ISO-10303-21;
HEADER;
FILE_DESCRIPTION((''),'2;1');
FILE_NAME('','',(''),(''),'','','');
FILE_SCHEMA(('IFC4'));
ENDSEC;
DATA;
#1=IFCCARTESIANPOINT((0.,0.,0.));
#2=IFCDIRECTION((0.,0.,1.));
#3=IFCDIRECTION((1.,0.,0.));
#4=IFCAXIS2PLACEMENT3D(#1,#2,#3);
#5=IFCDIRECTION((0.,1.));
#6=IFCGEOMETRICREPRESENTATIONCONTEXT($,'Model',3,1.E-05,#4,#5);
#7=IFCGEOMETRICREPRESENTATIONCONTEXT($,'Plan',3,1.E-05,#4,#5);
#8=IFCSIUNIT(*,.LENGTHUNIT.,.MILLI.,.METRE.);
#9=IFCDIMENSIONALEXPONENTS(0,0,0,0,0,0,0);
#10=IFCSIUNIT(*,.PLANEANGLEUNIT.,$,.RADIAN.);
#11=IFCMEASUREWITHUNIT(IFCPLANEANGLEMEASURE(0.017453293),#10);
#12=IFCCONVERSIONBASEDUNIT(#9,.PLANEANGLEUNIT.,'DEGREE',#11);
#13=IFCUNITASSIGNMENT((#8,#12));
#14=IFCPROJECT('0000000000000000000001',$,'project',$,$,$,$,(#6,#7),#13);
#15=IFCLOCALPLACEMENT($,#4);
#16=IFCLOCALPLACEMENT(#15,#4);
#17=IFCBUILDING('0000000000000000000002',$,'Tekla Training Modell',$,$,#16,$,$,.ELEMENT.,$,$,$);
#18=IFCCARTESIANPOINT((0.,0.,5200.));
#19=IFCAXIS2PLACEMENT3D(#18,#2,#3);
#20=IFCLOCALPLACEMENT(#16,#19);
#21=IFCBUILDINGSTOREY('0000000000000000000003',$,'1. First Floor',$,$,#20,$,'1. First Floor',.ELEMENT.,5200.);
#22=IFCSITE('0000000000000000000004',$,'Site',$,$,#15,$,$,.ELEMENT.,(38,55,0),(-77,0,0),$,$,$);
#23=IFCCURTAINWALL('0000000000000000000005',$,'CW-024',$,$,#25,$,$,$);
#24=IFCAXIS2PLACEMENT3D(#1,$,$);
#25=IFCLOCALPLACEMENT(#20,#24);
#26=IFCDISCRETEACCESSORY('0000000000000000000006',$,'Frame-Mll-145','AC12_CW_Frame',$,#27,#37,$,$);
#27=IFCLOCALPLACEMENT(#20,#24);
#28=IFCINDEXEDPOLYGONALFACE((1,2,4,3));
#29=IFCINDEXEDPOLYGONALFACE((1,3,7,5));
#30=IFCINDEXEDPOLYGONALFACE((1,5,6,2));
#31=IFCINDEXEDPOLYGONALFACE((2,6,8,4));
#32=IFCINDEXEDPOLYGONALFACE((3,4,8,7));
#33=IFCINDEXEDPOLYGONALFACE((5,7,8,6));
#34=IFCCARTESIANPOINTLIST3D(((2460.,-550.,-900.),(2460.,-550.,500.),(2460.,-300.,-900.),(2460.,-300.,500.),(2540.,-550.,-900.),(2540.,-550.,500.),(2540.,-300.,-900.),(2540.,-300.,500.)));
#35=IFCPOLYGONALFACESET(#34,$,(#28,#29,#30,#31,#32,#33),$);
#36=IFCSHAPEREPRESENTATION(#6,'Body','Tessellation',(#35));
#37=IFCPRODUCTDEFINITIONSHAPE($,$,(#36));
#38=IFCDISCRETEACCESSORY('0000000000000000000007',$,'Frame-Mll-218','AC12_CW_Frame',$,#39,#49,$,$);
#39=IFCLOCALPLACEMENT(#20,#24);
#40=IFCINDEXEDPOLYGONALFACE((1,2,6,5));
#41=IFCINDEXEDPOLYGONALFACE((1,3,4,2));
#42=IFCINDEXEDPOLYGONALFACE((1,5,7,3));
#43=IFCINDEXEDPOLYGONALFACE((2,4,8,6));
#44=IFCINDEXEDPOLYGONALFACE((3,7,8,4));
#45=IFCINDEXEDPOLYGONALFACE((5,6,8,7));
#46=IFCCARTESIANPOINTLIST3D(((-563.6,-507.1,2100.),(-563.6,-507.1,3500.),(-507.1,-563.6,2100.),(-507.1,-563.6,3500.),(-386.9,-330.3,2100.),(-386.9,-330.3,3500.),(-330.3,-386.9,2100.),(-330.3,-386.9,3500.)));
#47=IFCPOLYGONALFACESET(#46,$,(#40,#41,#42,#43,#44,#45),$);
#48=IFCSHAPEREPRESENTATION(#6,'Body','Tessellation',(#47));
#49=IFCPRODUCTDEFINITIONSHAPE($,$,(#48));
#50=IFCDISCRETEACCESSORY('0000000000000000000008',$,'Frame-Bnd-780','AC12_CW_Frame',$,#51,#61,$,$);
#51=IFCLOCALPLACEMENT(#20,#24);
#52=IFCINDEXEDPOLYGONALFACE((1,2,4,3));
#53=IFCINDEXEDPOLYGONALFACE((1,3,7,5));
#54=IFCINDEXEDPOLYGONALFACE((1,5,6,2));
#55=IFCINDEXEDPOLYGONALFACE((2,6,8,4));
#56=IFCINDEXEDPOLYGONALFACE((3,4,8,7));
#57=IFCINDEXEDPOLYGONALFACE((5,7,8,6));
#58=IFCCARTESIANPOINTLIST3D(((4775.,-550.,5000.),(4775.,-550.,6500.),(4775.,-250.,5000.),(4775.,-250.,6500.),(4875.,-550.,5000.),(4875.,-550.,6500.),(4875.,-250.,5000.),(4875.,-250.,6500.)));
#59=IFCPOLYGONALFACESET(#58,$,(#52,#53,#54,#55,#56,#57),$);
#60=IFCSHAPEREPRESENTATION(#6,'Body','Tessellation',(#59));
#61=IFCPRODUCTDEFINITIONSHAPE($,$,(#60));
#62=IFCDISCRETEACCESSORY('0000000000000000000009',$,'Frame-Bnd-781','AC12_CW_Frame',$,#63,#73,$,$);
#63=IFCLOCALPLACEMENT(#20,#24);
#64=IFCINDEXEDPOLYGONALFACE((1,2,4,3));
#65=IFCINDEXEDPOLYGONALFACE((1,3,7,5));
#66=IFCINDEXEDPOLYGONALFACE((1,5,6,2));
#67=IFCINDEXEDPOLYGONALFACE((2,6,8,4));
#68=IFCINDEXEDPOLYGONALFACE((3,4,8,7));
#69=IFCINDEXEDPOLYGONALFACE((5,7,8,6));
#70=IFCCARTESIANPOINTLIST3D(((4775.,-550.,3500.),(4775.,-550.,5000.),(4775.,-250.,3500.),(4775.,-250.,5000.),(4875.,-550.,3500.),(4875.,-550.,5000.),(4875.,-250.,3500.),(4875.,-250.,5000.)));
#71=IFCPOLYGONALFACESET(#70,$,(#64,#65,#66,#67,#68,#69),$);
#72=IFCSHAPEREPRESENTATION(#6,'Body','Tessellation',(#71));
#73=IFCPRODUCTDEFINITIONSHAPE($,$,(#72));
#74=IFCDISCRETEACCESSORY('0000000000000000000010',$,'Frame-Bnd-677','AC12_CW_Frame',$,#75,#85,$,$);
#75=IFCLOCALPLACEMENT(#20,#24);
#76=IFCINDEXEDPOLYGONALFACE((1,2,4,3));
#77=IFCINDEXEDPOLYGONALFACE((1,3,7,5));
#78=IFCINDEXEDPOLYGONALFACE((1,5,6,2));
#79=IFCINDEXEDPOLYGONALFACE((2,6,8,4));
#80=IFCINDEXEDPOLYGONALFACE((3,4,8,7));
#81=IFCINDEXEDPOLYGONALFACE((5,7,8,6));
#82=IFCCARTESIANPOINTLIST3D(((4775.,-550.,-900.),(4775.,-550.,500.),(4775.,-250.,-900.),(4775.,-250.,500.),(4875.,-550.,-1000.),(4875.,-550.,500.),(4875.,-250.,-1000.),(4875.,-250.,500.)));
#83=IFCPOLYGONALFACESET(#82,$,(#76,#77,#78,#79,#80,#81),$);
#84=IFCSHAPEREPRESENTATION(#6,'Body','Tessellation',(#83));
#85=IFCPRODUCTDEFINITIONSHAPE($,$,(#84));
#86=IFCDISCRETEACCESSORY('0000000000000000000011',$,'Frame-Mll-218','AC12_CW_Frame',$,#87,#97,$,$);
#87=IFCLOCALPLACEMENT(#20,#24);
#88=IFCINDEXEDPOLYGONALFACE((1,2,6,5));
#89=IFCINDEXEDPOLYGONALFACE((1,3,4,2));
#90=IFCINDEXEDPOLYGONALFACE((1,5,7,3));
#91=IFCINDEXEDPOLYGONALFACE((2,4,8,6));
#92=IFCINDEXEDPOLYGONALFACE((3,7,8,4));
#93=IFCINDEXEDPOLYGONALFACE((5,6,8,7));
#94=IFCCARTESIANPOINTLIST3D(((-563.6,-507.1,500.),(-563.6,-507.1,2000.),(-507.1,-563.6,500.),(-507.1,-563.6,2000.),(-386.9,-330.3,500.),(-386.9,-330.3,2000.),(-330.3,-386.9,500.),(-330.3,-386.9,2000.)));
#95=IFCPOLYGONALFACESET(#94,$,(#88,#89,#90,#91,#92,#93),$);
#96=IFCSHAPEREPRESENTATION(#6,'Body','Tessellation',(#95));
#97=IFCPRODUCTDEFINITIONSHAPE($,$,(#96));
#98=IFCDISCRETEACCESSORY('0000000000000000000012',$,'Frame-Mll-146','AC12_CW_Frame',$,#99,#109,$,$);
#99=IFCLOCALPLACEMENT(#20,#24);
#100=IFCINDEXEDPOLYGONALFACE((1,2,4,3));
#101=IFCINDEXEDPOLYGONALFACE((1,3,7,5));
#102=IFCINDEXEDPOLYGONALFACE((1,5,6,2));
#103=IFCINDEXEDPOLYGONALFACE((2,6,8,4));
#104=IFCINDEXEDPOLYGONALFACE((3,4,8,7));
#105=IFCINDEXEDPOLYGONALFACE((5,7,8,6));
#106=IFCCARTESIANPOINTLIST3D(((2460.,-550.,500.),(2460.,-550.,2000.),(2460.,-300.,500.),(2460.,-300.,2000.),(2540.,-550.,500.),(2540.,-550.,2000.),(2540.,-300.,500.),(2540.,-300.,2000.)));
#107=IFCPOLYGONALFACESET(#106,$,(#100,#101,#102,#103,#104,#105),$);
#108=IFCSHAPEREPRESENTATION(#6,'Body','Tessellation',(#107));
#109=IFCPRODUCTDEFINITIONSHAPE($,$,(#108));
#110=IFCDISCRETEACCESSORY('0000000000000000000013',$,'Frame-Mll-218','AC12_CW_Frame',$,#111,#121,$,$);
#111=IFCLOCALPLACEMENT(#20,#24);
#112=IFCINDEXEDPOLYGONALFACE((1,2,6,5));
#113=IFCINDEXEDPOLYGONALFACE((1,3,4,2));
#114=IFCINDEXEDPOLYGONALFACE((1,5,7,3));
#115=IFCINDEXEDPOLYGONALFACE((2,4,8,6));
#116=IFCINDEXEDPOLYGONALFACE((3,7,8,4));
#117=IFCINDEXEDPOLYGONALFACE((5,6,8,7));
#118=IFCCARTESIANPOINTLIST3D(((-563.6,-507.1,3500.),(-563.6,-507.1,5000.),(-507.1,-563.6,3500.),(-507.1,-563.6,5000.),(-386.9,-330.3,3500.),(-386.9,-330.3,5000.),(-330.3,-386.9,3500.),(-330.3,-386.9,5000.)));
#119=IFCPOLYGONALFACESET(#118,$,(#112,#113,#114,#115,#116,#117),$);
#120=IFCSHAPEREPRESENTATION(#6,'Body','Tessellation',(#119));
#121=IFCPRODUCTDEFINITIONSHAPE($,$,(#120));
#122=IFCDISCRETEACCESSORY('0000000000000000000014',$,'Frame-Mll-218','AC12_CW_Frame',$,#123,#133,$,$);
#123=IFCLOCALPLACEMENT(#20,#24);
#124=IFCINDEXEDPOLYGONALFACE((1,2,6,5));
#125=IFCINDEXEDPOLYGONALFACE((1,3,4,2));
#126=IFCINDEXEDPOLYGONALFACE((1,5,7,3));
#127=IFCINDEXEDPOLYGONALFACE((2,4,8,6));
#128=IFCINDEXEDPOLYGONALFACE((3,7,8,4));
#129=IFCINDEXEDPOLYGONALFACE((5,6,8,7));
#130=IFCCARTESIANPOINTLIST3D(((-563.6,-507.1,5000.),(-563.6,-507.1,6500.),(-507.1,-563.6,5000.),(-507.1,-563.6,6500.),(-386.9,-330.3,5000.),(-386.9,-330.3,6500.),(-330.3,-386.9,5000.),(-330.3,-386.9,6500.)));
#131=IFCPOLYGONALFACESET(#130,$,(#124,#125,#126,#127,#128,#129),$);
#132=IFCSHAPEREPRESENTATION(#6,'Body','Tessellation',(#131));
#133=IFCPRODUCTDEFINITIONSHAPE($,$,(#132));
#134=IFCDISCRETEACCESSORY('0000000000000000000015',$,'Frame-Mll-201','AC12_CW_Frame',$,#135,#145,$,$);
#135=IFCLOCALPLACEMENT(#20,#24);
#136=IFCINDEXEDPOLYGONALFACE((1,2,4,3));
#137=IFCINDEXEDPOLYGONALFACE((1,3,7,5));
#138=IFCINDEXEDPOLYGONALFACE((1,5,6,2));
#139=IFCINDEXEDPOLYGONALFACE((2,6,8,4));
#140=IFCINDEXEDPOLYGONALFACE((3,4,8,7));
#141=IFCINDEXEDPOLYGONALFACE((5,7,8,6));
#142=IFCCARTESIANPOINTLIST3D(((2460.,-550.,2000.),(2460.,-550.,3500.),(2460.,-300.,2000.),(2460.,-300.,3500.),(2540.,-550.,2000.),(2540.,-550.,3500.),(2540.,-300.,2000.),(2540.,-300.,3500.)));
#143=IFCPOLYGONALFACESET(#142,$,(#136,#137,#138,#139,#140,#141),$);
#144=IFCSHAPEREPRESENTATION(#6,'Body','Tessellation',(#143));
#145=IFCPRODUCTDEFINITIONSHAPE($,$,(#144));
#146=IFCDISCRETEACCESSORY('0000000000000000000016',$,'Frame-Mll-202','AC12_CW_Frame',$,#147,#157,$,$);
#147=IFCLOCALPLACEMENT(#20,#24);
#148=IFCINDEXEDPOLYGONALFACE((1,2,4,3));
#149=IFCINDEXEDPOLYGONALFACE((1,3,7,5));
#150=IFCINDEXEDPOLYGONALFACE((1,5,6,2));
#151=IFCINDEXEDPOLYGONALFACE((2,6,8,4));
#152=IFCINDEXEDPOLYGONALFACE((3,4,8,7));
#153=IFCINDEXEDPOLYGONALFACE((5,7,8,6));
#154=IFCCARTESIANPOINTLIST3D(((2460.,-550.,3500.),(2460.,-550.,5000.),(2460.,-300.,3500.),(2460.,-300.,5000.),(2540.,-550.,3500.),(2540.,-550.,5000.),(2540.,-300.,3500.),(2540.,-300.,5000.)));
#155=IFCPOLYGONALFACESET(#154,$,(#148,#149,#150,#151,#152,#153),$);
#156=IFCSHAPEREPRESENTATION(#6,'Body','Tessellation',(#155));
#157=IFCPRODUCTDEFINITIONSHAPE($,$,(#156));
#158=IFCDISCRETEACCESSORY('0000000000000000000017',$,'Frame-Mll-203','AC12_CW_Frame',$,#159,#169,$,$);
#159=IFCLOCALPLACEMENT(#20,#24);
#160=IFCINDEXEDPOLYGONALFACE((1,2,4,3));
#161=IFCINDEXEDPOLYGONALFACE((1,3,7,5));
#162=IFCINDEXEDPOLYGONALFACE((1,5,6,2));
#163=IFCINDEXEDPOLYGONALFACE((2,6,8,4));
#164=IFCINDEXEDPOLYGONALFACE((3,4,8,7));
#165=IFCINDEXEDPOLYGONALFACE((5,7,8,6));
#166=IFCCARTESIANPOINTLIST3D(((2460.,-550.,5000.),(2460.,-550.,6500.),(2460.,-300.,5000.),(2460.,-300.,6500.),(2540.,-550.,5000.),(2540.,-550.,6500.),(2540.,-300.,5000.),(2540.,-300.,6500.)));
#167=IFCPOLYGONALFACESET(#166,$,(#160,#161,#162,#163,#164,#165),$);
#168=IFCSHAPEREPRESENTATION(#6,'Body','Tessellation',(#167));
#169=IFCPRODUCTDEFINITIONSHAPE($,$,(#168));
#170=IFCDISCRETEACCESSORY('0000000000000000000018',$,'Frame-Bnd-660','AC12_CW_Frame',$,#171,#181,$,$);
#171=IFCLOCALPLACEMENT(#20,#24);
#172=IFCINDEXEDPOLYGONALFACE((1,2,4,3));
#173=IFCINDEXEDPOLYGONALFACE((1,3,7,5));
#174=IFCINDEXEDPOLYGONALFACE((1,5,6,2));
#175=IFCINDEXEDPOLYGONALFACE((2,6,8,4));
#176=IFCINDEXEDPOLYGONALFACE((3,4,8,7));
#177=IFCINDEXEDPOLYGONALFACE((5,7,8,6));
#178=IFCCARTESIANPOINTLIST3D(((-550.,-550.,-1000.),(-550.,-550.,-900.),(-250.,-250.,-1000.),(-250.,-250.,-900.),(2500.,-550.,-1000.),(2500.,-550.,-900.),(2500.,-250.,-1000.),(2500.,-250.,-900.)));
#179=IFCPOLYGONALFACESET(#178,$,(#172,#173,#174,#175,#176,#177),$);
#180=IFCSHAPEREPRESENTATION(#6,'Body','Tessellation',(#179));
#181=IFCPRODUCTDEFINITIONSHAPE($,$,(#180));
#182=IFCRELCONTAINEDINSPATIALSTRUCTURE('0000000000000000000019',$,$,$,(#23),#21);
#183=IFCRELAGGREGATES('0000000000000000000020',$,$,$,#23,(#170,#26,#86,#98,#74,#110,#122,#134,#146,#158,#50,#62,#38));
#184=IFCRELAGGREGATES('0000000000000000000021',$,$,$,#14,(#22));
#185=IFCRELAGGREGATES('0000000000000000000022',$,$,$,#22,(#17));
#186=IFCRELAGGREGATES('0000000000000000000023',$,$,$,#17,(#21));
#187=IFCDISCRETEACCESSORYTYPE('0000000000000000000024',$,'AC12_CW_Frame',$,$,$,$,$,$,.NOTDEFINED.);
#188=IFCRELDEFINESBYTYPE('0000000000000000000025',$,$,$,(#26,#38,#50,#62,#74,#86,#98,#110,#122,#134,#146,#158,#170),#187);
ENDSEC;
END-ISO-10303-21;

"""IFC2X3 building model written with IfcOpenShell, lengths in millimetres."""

from ifc_helpers import new_model, entity, si_unit, converted_unit, direction, frame, origin_with_axes, place, context, project, spatial, polyline, outline, extrude, source, transform, mapped, type_object, element, aggregate, save


model = new_model("IFC2X3")

# Units and contexts
model_context = context("Model", 3, precision=1e-05, world=origin_with_axes(), true_north=direction((0.0, 1.0)))
plan_context = context("Plan", 3, precision=1e-05, world=origin_with_axes(), true_north=direction((0.0, 1.0)))
ifc_project = project(units=[si_unit("LENGTHUNIT", "METRE", prefix="MILLI"), converted_unit("PLANEANGLEUNIT", "DEGREE", entity("IfcPlaneAngleMeasure", 0.017453293), si_unit("PLANEANGLEUNIT", "RADIAN"), dimensions=[0, 0, 0, 0, 0, 0, 0])], contexts=[model_context, plan_context])

# Site, building, storey
site_placement = place(None, origin_with_axes())
site = spatial("IfcSite", under=ifc_project, at=site_placement, Name="Site", CompositionType="ELEMENT", RefLatitude=(38, 55, 0), RefLongitude=(-77, 0, 0))
building_placement = place(site_placement, origin_with_axes())
building = spatial("IfcBuilding", under=site, at=building_placement, Name="Tekla Training Modell", CompositionType="ELEMENT")
storey_placement = place(building_placement, frame((0.0, 0.0, 5200.0), z_axis=(0.0, 0.0, 1.0), x_axis=(1.0, 0.0, 0.0)))
storey = spatial("IfcBuildingStorey", under=building, at=storey_placement, Name="1. First Floor", LongName="1. First Floor", CompositionType="ELEMENT", Elevation=5200.0)

# Curtain wall, discrete accessories
curtain_wall_placement = place(storey_placement, frame((-500.0, 6800.2, -1000.0), z_axis=(0.0, 0.0, 1.0), x_axis=(0.0, -1.0, 0.0)))
curtain_wall = element("IfcCurtainWall", 1, at=curtain_wall_placement, inside=storey, Name="CW-024")
discrete_accessory_type = type_object("IfcDiscreteAccessoryType", Name="AC12_CW_Frame")
shared_shape_1 = source(origin_with_axes(), model_context, "Body", "SweptSolid", [
    extrude(outline(polyline([(0.0, 0.0), (250.0, 0.0), (250.0, -1400.0), (0.0, -1400.0), (0.0, 0.0)])), origin_with_axes(), (0.0, 0.0, 1.0), 80.0),
])
discrete_accessory_1_placement = place(storey_placement, frame((2460.0, -300.0, -900.0), z_axis=(1.0, 0.0, 0.0), x_axis=(0.0, -1.0, 0.0)))
discrete_accessory_1 = element("IfcDiscreteAccessory", 2, at=discrete_accessory_1_placement, type_object=discrete_accessory_type, Name="Frame-Mll-145", Description="AC12_CW_Frame", context=model_context, shape_type="MappedRepresentation", body=[
    mapped(shared_shape_1, transform((0.0, 0.0, 0.0), scale=1.0)),
])
discrete_accessory_2_placement = place(storey_placement, frame((-386.9, -330.3, 2100.0), z_axis=(0.707107, -0.707107, 0.0), x_axis=(-0.707107, -0.707107, 0.0)))
discrete_accessory_2 = element("IfcDiscreteAccessory", 3, at=discrete_accessory_2_placement, type_object=discrete_accessory_type, Name="Frame-Mll-218", Description="AC12_CW_Frame", context=model_context, shape_type="MappedRepresentation", body=[
    mapped(shared_shape_1, transform((0.0, 0.0, 0.0), scale=1.0)),
])
shared_shape_2 = source(origin_with_axes(), model_context, "Body", "SweptSolid", [
    extrude(outline(polyline([(0.0, 0.0), (300.0, 0.0), (300.0, -1500.0), (0.0, -1500.0), (0.0, 0.0)])), origin_with_axes(), (0.0, 0.0, 1.0), 100.0),
])
discrete_accessory_3_placement = place(storey_placement, frame((4775.0, -250.0, 5000.0), z_axis=(1.0, 0.0, 0.0), x_axis=(0.0, -1.0, 0.0)))
discrete_accessory_3 = element("IfcDiscreteAccessory", 4, at=discrete_accessory_3_placement, type_object=discrete_accessory_type, Name="Frame-Bnd-780", Description="AC12_CW_Frame", context=model_context, shape_type="MappedRepresentation", body=[
    mapped(shared_shape_2, transform((0.0, 0.0, 0.0), scale=1.0)),
])
discrete_accessory_4_placement = place(storey_placement, frame((4775.0, -250.0, 3500.0), z_axis=(1.0, 0.0, 0.0), x_axis=(0.0, -1.0, 0.0)))
discrete_accessory_4 = element("IfcDiscreteAccessory", 5, at=discrete_accessory_4_placement, type_object=discrete_accessory_type, Name="Frame-Bnd-781", Description="AC12_CW_Frame", context=model_context, shape_type="MappedRepresentation", body=[
    mapped(shared_shape_2, transform((0.0, 0.0, 0.0), scale=1.0)),
])
shared_shape_3 = source(origin_with_axes(), model_context, "Body", "SweptSolid", [
    extrude(outline(polyline([(0.0, 0.0), (141.4, 0.0), (-919.2, -1060.7), (-989.9, -989.9), (0.0, 0.0)])), origin_with_axes(), (0.0, 0.0, 1.0), 300.0),
])
discrete_accessory_5_placement = place(storey_placement, frame((4775.0, -550.0, -900.0), z_axis=(0.0, 1.0, 0.0), x_axis=(0.707107, 0.0, -0.707107)))
discrete_accessory_5 = element("IfcDiscreteAccessory", 6, at=discrete_accessory_5_placement, type_object=discrete_accessory_type, Name="Frame-Bnd-677", Description="AC12_CW_Frame", context=model_context, shape_type="MappedRepresentation", body=[
    mapped(shared_shape_3, transform((0.0, 0.0, 0.0), scale=1.0)),
])
shared_shape_4 = source(origin_with_axes(), model_context, "Body", "SweptSolid", [
    extrude(outline(polyline([(0.0, 0.0), (250.0, 0.0), (250.0, -1500.0), (0.0, -1500.0), (0.0, 0.0)])), origin_with_axes(), (0.0, 0.0, 1.0), 80.0),
])
discrete_accessory_6_placement = place(storey_placement, frame((-386.9, -330.3, 500.0), z_axis=(0.707107, -0.707107, 0.0), x_axis=(-0.707107, -0.707107, 0.0)))
discrete_accessory_6 = element("IfcDiscreteAccessory", 7, at=discrete_accessory_6_placement, type_object=discrete_accessory_type, Name="Frame-Mll-218", Description="AC12_CW_Frame", context=model_context, shape_type="MappedRepresentation", body=[
    mapped(shared_shape_4, transform((0.0, 0.0, 0.0), scale=1.0)),
])
discrete_accessory_7_placement = place(storey_placement, frame((2460.0, -300.0, 500.0), z_axis=(1.0, 0.0, 0.0), x_axis=(0.0, -1.0, 0.0)))
discrete_accessory_7 = element("IfcDiscreteAccessory", 8, at=discrete_accessory_7_placement, type_object=discrete_accessory_type, Name="Frame-Mll-146", Description="AC12_CW_Frame", context=model_context, shape_type="MappedRepresentation", body=[
    mapped(shared_shape_4, transform((0.0, 0.0, 0.0), scale=1.0)),
])
discrete_accessory_8_placement = place(storey_placement, frame((-386.9, -330.3, 3500.0), z_axis=(0.707107, -0.707107, 0.0), x_axis=(-0.707107, -0.707107, 0.0)))
discrete_accessory_8 = element("IfcDiscreteAccessory", 9, at=discrete_accessory_8_placement, type_object=discrete_accessory_type, Name="Frame-Mll-218", Description="AC12_CW_Frame", context=model_context, shape_type="MappedRepresentation", body=[
    mapped(shared_shape_4, transform((0.0, 0.0, 0.0), scale=1.0)),
])
discrete_accessory_9_placement = place(storey_placement, frame((-386.9, -330.3, 5000.0), z_axis=(0.707107, -0.707107, 0.0), x_axis=(-0.707107, -0.707107, 0.0)))
discrete_accessory_9 = element("IfcDiscreteAccessory", 10, at=discrete_accessory_9_placement, type_object=discrete_accessory_type, Name="Frame-Mll-218", Description="AC12_CW_Frame", context=model_context, shape_type="MappedRepresentation", body=[
    mapped(shared_shape_4, transform((0.0, 0.0, 0.0), scale=1.0)),
])
discrete_accessory_10_placement = place(storey_placement, frame((2460.0, -300.0, 2000.0), z_axis=(1.0, 0.0, 0.0), x_axis=(0.0, -1.0, 0.0)))
discrete_accessory_10 = element("IfcDiscreteAccessory", 11, at=discrete_accessory_10_placement, type_object=discrete_accessory_type, Name="Frame-Mll-201", Description="AC12_CW_Frame", context=model_context, shape_type="MappedRepresentation", body=[
    mapped(shared_shape_4, transform((0.0, 0.0, 0.0), scale=1.0)),
])
discrete_accessory_11_placement = place(storey_placement, frame((2460.0, -300.0, 3500.0), z_axis=(1.0, 0.0, 0.0), x_axis=(0.0, -1.0, 0.0)))
discrete_accessory_11 = element("IfcDiscreteAccessory", 12, at=discrete_accessory_11_placement, type_object=discrete_accessory_type, Name="Frame-Mll-202", Description="AC12_CW_Frame", context=model_context, shape_type="MappedRepresentation", body=[
    mapped(shared_shape_4, transform((0.0, 0.0, 0.0), scale=1.0)),
])
discrete_accessory_12_placement = place(storey_placement, frame((2460.0, -300.0, 5000.0), z_axis=(1.0, 0.0, 0.0), x_axis=(0.0, -1.0, 0.0)))
discrete_accessory_12 = element("IfcDiscreteAccessory", 13, at=discrete_accessory_12_placement, type_object=discrete_accessory_type, Name="Frame-Mll-203", Description="AC12_CW_Frame", context=model_context, shape_type="MappedRepresentation", body=[
    mapped(shared_shape_4, transform((0.0, 0.0, 0.0), scale=1.0)),
])
shared_shape_5 = source(origin_with_axes(), model_context, "Body", "SweptSolid", [
    extrude(outline(polyline([(0.0, 0.0), (424.3, 0.0), (-1732.4, -2156.7), (-1944.5, -1944.5), (0.0, 0.0)])), origin_with_axes(), (0.0, 0.0, 1.0), 100.0),
])
discrete_accessory_13_placement = place(storey_placement, frame((-250.0, -250.0, -900.0), z_axis=(0.0, 0.0, -1.0), x_axis=(-0.707107, -0.707107, 0.0)))
discrete_accessory_13 = element("IfcDiscreteAccessory", 14, at=discrete_accessory_13_placement, type_object=discrete_accessory_type, Name="Frame-Bnd-660", Description="AC12_CW_Frame", context=model_context, shape_type="MappedRepresentation", body=[
    mapped(shared_shape_5, transform((0.0, 0.0, 0.0), scale=1.0)),
])
aggregate(curtain_wall, [discrete_accessory_13, discrete_accessory_1, discrete_accessory_6, discrete_accessory_7, discrete_accessory_5, discrete_accessory_8, discrete_accessory_9, discrete_accessory_10, discrete_accessory_11, discrete_accessory_12, discrete_accessory_3, discrete_accessory_4, discrete_accessory_2])

save(model, "model.ifc")
